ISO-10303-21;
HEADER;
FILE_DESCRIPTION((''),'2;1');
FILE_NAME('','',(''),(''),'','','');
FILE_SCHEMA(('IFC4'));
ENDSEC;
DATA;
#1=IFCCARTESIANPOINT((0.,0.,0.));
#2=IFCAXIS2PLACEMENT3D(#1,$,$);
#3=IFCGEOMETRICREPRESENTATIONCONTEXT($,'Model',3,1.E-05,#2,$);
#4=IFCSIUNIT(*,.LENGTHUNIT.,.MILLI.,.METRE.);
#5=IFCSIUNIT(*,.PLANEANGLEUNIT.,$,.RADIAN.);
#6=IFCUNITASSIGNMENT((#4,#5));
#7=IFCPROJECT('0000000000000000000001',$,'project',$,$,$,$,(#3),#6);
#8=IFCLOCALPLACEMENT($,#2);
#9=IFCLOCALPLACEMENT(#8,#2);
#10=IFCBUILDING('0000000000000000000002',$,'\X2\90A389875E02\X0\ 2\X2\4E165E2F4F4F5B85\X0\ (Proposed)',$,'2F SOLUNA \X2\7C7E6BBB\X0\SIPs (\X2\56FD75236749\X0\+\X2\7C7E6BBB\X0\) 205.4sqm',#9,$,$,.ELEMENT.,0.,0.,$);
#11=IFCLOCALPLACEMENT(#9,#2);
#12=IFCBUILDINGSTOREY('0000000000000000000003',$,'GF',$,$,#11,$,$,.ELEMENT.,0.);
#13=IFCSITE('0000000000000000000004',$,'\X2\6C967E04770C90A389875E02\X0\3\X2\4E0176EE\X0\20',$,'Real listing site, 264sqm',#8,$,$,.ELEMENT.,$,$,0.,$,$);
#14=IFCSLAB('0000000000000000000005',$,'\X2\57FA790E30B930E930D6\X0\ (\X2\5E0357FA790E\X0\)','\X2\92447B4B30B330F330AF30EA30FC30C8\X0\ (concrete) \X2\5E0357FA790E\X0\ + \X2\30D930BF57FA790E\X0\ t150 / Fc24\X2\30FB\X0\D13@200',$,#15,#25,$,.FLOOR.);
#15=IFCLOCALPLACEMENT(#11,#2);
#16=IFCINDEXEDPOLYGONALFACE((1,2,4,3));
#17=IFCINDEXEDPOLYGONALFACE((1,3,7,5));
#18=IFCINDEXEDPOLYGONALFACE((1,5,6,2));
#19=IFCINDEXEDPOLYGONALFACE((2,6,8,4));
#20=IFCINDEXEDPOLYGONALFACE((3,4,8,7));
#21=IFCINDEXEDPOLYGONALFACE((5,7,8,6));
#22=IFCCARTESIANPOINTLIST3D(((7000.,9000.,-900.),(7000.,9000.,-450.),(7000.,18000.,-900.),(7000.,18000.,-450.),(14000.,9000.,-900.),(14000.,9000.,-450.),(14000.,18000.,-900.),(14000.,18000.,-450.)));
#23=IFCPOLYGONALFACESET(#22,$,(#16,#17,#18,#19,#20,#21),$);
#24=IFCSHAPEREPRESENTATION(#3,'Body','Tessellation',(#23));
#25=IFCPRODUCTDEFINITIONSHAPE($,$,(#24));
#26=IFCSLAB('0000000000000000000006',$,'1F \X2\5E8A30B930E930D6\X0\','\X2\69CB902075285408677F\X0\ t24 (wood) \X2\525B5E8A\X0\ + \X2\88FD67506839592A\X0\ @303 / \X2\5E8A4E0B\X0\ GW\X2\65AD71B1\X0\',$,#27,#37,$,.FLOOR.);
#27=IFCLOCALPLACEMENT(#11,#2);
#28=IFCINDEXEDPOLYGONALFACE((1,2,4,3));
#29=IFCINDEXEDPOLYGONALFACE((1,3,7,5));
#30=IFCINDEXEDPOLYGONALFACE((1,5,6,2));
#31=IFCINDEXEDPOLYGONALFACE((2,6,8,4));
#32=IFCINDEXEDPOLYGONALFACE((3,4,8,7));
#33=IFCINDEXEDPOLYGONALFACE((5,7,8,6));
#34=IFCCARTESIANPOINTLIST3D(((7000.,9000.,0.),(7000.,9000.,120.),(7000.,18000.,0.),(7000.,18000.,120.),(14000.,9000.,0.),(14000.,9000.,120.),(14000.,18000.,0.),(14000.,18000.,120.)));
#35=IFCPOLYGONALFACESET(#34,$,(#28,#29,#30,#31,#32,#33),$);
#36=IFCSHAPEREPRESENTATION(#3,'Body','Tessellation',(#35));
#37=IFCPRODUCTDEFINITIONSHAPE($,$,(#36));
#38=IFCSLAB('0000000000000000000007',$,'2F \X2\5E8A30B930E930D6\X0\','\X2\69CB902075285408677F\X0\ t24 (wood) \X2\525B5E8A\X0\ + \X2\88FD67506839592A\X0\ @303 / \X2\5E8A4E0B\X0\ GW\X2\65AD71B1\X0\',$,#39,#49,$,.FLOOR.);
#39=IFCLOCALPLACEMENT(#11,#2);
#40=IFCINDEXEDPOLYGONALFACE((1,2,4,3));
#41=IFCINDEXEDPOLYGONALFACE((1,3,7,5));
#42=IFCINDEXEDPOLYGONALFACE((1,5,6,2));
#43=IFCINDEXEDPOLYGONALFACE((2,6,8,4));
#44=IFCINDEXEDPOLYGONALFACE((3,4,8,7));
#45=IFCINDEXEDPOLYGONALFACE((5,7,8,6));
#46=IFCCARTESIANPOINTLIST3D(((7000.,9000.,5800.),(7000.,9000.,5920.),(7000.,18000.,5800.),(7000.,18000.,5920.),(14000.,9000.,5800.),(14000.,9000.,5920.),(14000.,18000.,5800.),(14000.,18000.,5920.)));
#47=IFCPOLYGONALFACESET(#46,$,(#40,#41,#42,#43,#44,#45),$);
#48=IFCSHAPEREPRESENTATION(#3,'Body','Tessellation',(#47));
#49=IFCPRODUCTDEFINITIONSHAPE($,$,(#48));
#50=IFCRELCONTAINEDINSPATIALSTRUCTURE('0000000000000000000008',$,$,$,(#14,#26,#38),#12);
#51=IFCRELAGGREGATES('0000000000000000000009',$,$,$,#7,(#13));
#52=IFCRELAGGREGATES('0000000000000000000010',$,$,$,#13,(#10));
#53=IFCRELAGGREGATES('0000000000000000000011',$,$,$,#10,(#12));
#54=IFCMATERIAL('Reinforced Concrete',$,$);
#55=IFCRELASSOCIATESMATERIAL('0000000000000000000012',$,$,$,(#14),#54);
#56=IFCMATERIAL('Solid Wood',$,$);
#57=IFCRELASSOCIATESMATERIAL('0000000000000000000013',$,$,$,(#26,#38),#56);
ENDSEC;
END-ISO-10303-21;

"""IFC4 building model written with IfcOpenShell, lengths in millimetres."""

from ifc_helpers import new_model, si_unit, frame, frame_2d, origin, place, context, project, spatial, rectangle, extrude, material, element, save


model = new_model("IFC4")

# Units and contexts
model_context = context("Model", 3, precision=1e-05, world=origin())
ifc_project = project(units=[si_unit("LENGTHUNIT", "METRE", prefix="MILLI"), si_unit("PLANEANGLEUNIT", "RADIAN")], contexts=[model_context])

# Site, building, storey
site_placement = place(None, origin())
site = spatial("IfcSite", under=ifc_project, at=site_placement, Name="沖縄県那覇市3丁目20", ObjectType="Real listing site, 264sqm", CompositionType="ELEMENT", RefElevation=0.0)
building_placement = place(site_placement, origin())
building = spatial("IfcBuilding", under=site, at=building_placement, Name="那覇市 2世帯住宅 (Proposed)", ObjectType="2F SOLUNA 籾殻SIPs (国産杉+籾殻) 205.4sqm", CompositionType="ELEMENT", ElevationOfRefHeight=0.0, ElevationOfTerrain=0.0)
storey_placement = place(building_placement, origin())
storey = spatial("IfcBuildingStorey", under=building, at=storey_placement, Name="GF", CompositionType="ELEMENT", Elevation=0.0)

# Slabs
ifc_material_1 = material(Name="Reinforced Concrete")
slab_1_placement = place(storey_placement, frame((3500.0, 4500.0, -450.0)))
element("IfcSlab", 1, at=slab_1_placement, inside=storey, material=ifc_material_1, Name="基礎スラブ (布基礎)", Description="鉄筋コンクリート (concrete) 布基礎 + ベタ基礎 t150 / Fc24・D13@200", PredefinedType="FLOOR", context=model_context, shape_type="SweptSolid", body=[
    extrude(rectangle(XDim=7000.0, YDim=9000.0, at=frame_2d((3500.0, 4500.0))), frame((3500.0, 4500.0, -450.0)), (0.0, 0.0, 1.0), 450.0),
])
ifc_material_2 = material(Name="Solid Wood")
slab_2_placement = place(storey_placement, frame((3500.0, 4500.0, 0.0)))
element("IfcSlab", 2, at=slab_2_placement, inside=storey, material=ifc_material_2, Name="1F 床スラブ", Description="構造用合板 t24 (wood) 剛床 + 製材根太 @303 / 床下 GW断熱", PredefinedType="FLOOR", context=model_context, shape_type="SweptSolid", body=[
    extrude(rectangle(XDim=7000.0, YDim=9000.0, at=frame_2d((3500.0, 4500.0))), frame((3500.0, 4500.0, 0.0)), (0.0, 0.0, 1.0), 120.0),
])
slab_3_placement = place(storey_placement, frame((3500.0, 4500.0, 2900.0)))
element("IfcSlab", 3, at=slab_3_placement, inside=storey, material=ifc_material_2, Name="2F 床スラブ", Description="構造用合板 t24 (wood) 剛床 + 製材根太 @303 / 床下 GW断熱", PredefinedType="FLOOR", context=model_context, shape_type="SweptSolid", body=[
    extrude(rectangle(XDim=7000.0, YDim=9000.0, at=frame_2d((3500.0, 4500.0))), frame((3500.0, 4500.0, 2900.0)), (0.0, 0.0, 1.0), 120.0),
])

save(model, "model.ifc")
